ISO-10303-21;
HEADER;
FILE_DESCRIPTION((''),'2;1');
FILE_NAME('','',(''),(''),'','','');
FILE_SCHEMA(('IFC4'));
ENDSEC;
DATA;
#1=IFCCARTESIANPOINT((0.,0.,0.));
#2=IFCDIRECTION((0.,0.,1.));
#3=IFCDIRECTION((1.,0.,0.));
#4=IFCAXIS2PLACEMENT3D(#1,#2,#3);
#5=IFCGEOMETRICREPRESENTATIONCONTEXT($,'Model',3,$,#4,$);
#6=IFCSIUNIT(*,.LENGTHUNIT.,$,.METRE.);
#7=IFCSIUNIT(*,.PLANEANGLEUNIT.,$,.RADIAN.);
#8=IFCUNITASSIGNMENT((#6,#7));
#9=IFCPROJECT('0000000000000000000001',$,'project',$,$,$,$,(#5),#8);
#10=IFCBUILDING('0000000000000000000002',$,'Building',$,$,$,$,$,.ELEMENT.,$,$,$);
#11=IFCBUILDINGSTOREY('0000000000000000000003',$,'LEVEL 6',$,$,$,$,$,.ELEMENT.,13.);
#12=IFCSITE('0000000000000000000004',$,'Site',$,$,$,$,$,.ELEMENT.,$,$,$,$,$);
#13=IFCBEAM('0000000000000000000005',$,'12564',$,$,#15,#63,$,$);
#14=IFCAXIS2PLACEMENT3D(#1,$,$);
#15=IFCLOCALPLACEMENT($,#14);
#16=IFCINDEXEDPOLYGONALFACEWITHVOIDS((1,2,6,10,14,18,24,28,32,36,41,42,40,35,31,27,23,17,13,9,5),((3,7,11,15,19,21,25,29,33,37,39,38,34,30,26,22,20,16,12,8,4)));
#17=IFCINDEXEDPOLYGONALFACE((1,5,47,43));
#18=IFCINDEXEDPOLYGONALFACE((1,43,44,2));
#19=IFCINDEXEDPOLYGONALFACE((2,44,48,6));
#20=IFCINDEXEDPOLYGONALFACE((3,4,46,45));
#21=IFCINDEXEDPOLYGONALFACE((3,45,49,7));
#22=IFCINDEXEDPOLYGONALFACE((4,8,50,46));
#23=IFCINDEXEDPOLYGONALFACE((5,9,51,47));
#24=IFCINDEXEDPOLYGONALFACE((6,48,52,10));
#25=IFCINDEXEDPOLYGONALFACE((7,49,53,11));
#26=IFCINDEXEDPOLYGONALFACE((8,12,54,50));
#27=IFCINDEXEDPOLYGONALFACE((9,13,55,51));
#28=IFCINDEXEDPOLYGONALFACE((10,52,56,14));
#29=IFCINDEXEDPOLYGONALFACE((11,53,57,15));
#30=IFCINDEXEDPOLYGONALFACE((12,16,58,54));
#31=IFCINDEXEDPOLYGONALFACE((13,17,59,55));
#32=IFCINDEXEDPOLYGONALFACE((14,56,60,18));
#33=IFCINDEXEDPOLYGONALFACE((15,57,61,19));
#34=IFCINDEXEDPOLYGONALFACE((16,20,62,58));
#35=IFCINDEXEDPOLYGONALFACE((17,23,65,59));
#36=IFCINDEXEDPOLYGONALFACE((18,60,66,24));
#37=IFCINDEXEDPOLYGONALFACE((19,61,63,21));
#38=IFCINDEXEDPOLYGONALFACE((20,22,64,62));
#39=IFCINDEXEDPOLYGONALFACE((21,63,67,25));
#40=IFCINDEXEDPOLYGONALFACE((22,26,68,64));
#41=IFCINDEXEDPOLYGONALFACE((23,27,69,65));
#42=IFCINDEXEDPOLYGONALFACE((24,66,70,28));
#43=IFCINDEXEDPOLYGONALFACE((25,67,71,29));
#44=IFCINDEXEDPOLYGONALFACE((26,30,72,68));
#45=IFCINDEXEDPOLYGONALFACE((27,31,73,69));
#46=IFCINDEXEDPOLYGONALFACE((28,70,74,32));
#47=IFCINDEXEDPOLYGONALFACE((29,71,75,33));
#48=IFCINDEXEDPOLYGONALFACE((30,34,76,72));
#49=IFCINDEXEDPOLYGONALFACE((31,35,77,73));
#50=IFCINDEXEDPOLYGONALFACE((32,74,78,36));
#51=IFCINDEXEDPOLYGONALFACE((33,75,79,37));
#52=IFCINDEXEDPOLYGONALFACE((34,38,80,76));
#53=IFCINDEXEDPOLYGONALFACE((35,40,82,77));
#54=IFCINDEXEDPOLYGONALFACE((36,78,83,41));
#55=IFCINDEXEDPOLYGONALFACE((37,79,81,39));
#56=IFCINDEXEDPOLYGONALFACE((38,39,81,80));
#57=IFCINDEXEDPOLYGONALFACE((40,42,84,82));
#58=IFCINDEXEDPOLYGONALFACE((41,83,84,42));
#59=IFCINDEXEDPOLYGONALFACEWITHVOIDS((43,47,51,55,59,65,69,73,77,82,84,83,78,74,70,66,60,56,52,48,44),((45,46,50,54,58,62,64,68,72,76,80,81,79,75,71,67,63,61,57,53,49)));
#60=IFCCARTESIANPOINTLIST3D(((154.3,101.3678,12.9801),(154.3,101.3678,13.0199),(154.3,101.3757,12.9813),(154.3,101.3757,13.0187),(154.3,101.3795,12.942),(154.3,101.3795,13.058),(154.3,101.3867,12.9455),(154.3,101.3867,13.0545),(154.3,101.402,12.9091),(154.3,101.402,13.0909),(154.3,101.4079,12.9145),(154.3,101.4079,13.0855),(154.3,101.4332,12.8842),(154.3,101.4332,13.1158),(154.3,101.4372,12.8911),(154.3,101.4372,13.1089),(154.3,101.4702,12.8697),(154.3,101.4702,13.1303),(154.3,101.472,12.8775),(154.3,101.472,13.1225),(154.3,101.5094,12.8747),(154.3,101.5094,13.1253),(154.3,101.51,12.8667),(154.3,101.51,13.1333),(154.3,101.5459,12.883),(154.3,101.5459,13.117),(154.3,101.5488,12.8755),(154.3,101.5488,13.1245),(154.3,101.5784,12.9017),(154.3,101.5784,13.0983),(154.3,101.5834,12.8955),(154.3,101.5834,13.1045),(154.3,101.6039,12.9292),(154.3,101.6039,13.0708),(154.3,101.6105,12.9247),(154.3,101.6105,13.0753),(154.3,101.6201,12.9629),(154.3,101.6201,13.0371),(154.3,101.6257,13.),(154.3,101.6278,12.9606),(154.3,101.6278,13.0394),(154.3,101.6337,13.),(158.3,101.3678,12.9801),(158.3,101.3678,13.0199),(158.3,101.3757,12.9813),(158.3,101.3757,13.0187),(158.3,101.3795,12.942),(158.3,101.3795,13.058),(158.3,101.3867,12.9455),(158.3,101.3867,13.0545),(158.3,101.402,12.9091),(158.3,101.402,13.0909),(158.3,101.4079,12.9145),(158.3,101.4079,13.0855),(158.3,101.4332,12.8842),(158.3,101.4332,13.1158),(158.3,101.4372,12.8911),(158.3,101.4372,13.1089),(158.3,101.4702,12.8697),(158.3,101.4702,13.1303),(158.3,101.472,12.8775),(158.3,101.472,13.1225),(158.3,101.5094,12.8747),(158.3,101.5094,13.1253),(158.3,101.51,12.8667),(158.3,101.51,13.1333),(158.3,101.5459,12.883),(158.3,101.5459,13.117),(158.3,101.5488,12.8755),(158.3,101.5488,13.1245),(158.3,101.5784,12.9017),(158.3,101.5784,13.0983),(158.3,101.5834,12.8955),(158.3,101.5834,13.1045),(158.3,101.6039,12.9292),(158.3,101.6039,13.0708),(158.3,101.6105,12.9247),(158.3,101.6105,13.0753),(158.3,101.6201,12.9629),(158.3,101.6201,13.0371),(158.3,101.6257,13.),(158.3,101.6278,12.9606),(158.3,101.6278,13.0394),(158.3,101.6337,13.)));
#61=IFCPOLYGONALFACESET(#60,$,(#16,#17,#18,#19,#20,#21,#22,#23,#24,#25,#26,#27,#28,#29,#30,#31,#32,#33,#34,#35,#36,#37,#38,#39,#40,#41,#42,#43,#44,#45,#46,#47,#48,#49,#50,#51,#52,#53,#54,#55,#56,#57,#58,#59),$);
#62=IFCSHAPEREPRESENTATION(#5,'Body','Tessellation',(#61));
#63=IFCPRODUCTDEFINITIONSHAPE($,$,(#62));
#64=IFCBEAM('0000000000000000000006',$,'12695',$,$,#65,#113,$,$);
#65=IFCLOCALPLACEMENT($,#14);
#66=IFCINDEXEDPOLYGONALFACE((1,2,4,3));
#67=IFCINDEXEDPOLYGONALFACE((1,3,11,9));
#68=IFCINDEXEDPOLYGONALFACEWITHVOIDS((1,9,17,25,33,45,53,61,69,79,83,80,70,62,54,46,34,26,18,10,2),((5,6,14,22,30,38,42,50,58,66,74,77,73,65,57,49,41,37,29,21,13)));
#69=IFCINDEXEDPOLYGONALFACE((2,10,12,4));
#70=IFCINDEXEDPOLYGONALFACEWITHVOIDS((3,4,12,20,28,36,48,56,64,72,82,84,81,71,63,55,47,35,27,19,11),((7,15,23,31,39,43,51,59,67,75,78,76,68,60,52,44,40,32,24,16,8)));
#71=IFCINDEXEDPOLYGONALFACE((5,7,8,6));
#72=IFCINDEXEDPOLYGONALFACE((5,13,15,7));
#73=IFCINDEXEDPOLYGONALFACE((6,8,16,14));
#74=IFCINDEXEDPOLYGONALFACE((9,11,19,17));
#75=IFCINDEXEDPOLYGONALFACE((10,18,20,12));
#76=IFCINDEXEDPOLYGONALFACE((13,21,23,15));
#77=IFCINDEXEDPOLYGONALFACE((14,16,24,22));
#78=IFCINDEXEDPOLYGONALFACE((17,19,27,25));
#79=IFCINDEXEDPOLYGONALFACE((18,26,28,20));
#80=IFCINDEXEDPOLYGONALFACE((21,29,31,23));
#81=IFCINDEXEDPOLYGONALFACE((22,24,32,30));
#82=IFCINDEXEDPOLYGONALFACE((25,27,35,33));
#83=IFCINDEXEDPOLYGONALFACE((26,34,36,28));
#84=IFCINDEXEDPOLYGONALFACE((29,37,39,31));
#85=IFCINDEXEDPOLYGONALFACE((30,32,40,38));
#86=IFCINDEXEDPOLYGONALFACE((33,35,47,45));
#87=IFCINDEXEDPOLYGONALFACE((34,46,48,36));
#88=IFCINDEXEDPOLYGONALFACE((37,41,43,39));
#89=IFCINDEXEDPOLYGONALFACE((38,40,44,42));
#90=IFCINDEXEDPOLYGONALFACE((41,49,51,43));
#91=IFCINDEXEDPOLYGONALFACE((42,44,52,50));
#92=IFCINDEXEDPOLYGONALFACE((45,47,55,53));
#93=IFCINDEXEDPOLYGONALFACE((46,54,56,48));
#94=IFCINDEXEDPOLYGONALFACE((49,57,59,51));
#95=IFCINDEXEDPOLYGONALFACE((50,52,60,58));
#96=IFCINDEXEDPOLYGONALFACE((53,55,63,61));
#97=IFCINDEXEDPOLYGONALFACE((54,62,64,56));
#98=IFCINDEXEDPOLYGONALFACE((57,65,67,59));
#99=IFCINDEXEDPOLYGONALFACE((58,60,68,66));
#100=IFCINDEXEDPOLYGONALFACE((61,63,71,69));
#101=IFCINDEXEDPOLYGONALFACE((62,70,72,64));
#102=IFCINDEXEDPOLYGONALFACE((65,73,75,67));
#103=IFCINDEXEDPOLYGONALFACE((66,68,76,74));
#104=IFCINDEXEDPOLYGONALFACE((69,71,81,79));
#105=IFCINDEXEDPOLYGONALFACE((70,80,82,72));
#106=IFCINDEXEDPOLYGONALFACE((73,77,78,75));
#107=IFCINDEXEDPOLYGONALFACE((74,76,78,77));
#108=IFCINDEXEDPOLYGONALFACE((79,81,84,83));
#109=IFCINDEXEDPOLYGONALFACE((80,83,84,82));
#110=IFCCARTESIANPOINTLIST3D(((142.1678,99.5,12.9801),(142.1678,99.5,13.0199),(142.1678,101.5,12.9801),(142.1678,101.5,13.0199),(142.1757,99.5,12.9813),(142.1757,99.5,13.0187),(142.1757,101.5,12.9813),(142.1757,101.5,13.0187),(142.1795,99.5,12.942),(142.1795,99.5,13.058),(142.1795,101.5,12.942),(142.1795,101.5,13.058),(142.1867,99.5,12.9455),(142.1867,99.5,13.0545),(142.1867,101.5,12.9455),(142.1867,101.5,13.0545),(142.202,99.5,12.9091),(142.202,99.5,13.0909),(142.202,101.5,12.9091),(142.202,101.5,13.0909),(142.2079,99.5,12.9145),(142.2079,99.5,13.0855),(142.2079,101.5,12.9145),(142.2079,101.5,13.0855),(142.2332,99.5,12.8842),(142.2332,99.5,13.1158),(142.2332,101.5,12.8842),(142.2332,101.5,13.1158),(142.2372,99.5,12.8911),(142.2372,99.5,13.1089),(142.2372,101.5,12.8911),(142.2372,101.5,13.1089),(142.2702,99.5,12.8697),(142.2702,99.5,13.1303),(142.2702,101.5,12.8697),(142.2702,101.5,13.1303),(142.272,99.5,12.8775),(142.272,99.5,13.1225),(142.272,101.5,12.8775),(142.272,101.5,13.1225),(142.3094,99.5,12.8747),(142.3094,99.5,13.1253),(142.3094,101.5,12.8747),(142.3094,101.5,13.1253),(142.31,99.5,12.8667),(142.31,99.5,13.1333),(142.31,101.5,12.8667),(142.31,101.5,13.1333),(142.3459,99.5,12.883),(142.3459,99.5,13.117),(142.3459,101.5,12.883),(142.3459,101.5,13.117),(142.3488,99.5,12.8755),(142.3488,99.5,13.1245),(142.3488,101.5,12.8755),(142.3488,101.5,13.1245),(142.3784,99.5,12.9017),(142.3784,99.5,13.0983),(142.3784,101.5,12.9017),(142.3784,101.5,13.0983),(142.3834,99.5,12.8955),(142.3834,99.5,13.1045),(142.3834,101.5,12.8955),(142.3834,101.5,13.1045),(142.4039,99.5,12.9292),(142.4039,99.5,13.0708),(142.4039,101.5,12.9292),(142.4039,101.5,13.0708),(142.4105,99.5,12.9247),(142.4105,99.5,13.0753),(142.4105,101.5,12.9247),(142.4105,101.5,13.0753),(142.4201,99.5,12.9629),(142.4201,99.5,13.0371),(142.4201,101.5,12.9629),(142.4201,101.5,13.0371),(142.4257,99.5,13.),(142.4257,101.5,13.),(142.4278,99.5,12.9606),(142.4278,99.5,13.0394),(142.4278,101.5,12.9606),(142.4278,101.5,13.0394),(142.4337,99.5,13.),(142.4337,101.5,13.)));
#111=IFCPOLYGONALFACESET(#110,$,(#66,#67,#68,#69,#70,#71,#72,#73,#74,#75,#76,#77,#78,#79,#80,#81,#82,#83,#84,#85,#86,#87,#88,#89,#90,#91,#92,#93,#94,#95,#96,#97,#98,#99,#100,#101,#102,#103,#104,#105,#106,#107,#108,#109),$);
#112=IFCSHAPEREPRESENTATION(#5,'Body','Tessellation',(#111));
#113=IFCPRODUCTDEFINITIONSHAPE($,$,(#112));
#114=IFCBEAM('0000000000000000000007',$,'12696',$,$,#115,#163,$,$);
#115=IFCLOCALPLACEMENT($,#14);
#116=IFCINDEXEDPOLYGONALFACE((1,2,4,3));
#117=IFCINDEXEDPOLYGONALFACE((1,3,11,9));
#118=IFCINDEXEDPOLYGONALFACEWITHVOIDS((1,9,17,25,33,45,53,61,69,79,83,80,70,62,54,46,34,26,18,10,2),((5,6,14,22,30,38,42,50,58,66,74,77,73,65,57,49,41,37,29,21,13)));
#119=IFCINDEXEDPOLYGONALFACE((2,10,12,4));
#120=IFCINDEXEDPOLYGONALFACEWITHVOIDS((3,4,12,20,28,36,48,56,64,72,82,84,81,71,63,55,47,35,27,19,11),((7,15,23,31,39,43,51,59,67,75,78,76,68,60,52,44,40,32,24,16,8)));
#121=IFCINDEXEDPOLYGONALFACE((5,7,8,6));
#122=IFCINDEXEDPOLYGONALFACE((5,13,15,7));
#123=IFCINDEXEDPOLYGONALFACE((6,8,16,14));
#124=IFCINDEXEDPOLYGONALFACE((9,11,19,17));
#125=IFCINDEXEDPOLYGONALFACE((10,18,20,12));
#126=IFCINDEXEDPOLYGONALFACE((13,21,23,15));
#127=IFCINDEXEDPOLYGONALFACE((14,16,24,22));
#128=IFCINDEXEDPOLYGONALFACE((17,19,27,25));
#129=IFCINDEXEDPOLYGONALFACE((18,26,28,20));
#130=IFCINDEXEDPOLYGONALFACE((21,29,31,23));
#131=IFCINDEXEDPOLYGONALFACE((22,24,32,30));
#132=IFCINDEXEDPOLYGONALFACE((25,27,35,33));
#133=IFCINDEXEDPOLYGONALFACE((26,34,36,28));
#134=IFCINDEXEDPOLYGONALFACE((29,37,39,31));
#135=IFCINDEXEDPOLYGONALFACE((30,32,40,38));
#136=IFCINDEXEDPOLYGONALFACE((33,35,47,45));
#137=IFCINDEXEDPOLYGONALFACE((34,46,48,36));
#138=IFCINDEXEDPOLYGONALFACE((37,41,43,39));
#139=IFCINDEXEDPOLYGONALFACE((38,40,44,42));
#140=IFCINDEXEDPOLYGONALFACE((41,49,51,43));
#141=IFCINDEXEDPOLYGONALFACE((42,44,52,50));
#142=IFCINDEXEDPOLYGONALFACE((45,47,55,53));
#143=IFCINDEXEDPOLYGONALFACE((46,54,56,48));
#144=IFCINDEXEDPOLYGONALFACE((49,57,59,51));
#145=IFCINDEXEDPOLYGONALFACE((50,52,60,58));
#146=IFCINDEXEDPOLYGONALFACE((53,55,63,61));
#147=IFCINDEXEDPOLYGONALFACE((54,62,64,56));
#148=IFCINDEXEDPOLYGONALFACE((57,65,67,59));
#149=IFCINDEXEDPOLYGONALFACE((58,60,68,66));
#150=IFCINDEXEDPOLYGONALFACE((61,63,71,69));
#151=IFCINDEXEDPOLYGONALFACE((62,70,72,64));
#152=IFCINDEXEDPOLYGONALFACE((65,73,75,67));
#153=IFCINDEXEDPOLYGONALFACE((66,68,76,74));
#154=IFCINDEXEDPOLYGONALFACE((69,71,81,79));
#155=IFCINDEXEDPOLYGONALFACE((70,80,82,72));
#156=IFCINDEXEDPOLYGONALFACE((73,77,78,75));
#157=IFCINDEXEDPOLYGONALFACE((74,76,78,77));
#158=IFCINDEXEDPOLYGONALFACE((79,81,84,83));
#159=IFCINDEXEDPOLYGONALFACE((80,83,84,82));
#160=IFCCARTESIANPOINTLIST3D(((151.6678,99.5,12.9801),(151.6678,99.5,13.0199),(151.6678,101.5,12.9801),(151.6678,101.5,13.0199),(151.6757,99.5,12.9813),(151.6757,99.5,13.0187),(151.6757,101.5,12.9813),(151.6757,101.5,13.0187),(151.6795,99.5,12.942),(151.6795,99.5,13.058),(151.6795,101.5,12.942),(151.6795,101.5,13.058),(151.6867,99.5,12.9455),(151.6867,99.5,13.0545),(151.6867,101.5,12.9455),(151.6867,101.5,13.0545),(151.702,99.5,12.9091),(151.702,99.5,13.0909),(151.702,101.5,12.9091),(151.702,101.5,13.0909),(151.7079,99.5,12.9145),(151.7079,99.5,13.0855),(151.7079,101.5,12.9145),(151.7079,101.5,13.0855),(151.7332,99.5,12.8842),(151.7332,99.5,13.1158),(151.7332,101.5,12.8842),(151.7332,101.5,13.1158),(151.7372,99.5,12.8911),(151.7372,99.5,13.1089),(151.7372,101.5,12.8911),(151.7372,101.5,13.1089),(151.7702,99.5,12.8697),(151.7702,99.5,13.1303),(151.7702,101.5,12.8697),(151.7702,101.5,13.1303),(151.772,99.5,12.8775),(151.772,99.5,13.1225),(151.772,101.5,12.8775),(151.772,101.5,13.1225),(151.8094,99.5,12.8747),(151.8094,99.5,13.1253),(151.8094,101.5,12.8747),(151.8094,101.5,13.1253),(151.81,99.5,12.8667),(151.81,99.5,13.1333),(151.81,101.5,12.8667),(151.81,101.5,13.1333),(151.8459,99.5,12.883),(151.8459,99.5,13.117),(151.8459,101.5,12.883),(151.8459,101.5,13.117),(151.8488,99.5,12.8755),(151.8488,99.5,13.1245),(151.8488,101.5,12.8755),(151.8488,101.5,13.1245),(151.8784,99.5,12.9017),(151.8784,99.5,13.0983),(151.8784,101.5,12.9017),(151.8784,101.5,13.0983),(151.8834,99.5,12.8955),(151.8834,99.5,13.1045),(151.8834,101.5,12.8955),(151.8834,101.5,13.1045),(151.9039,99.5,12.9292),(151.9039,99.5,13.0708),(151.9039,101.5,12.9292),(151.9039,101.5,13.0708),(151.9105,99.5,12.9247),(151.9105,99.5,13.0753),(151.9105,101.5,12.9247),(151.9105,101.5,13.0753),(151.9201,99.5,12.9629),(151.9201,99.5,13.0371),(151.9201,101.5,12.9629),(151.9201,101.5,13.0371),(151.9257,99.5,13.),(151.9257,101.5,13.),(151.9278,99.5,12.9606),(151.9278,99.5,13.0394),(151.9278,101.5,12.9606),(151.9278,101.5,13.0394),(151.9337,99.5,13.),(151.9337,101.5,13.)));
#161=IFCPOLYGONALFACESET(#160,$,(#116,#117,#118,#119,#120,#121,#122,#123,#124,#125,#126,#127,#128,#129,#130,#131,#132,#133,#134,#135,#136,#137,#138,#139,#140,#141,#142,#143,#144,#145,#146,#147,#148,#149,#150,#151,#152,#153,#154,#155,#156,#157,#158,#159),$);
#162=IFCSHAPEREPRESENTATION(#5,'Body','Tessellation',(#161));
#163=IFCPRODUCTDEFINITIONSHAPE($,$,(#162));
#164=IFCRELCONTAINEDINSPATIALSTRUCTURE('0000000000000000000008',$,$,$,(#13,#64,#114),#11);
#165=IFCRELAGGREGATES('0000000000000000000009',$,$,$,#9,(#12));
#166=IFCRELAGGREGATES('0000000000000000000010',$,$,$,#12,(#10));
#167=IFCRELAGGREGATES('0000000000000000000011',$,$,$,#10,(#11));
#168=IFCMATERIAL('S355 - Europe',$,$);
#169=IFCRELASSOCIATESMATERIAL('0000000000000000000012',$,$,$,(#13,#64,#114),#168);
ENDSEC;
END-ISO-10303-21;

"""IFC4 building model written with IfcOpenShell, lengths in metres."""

from ifc_helpers import new_model, si_unit, frame, origin_with_axes, origin_2d_with_axis, place, context, project, spatial, hollow_circle, extrude, material, material_profile, profile_set, profile_usage, element, save


model = new_model("IFC4")

# Units and contexts
model_context = context("Model", 3, world=origin_with_axes())
ifc_project = project(units=[si_unit("LENGTHUNIT", "METRE"), si_unit("PLANEANGLEUNIT", "RADIAN")], contexts=[model_context])

# Site, building, storey
site = spatial("IfcSite", under=ifc_project, Name="Site", CompositionType="ELEMENT")
building = spatial("IfcBuilding", under=site, Name="Building", CompositionType="ELEMENT")
storey = spatial("IfcBuildingStorey", under=building, Name="LEVEL 6", CompositionType="ELEMENT", Elevation=13.0)

# Shared definitions
ifc_material = material(Name="S355 - Europe")

# Beams
ifc_material_profile_1 = material_profile(ifc_material, hollow_circle(Radius=0.1337, WallThickness=0.008, at=origin_2d_with_axis()))
ifc_profile_set_1 = profile_set([ifc_material_profile_1])
ifc_profile_usage_1 = profile_usage(ifc_profile_set_1, cardinal=10)
beam_1_placement = place(None, frame((154.3, 101.5, 13.0), z_axis=(1.0, 0.0, 0.0), x_axis=(0.0, 1.0, 0.0)))
element("IfcBeam", 1, at=beam_1_placement, inside=storey, material=ifc_profile_usage_1, Name="12564", context=model_context, shape_type="SweptSolid", body=[
    extrude(hollow_circle(Radius=0.1337, WallThickness=0.008, at=origin_2d_with_axis()), origin_with_axes(), (0.0, 0.0, 1.0), 4.0),
])
ifc_material_profile_2 = material_profile(ifc_material, hollow_circle(Radius=0.1337, WallThickness=0.008, at=origin_2d_with_axis()))
ifc_profile_set_2 = profile_set([ifc_material_profile_2])
ifc_profile_usage_2 = profile_usage(ifc_profile_set_2, cardinal=10)
beam_2_placement = place(None, frame((142.3, 101.5, 13.0), z_axis=(0.0, -1.0, 0.0), x_axis=(1.0, 0.0, 0.0)))
element("IfcBeam", 2, at=beam_2_placement, inside=storey, material=ifc_profile_usage_2, Name="12695", context=model_context, shape_type="SweptSolid", body=[
    extrude(hollow_circle(Radius=0.1337, WallThickness=0.008, at=origin_2d_with_axis()), origin_with_axes(), (0.0, 0.0, 1.0), 2.0),
])
ifc_material_profile_3 = material_profile(ifc_material, hollow_circle(Radius=0.1337, WallThickness=0.008, at=origin_2d_with_axis()))
ifc_profile_set_3 = profile_set([ifc_material_profile_3])
ifc_profile_usage_3 = profile_usage(ifc_profile_set_3, cardinal=10)
beam_3_placement = place(None, frame((151.8, 101.5, 13.0), z_axis=(0.0, -1.0, 0.0), x_axis=(1.0, 0.0, 0.0)))
element("IfcBeam", 3, at=beam_3_placement, inside=storey, material=ifc_profile_usage_3, Name="12696", context=model_context, shape_type="SweptSolid", body=[
    extrude(hollow_circle(Radius=0.1337, WallThickness=0.008, at=origin_2d_with_axis()), origin_with_axes(), (0.0, 0.0, 1.0), 2.0),
])

save(model, "model.ifc")
